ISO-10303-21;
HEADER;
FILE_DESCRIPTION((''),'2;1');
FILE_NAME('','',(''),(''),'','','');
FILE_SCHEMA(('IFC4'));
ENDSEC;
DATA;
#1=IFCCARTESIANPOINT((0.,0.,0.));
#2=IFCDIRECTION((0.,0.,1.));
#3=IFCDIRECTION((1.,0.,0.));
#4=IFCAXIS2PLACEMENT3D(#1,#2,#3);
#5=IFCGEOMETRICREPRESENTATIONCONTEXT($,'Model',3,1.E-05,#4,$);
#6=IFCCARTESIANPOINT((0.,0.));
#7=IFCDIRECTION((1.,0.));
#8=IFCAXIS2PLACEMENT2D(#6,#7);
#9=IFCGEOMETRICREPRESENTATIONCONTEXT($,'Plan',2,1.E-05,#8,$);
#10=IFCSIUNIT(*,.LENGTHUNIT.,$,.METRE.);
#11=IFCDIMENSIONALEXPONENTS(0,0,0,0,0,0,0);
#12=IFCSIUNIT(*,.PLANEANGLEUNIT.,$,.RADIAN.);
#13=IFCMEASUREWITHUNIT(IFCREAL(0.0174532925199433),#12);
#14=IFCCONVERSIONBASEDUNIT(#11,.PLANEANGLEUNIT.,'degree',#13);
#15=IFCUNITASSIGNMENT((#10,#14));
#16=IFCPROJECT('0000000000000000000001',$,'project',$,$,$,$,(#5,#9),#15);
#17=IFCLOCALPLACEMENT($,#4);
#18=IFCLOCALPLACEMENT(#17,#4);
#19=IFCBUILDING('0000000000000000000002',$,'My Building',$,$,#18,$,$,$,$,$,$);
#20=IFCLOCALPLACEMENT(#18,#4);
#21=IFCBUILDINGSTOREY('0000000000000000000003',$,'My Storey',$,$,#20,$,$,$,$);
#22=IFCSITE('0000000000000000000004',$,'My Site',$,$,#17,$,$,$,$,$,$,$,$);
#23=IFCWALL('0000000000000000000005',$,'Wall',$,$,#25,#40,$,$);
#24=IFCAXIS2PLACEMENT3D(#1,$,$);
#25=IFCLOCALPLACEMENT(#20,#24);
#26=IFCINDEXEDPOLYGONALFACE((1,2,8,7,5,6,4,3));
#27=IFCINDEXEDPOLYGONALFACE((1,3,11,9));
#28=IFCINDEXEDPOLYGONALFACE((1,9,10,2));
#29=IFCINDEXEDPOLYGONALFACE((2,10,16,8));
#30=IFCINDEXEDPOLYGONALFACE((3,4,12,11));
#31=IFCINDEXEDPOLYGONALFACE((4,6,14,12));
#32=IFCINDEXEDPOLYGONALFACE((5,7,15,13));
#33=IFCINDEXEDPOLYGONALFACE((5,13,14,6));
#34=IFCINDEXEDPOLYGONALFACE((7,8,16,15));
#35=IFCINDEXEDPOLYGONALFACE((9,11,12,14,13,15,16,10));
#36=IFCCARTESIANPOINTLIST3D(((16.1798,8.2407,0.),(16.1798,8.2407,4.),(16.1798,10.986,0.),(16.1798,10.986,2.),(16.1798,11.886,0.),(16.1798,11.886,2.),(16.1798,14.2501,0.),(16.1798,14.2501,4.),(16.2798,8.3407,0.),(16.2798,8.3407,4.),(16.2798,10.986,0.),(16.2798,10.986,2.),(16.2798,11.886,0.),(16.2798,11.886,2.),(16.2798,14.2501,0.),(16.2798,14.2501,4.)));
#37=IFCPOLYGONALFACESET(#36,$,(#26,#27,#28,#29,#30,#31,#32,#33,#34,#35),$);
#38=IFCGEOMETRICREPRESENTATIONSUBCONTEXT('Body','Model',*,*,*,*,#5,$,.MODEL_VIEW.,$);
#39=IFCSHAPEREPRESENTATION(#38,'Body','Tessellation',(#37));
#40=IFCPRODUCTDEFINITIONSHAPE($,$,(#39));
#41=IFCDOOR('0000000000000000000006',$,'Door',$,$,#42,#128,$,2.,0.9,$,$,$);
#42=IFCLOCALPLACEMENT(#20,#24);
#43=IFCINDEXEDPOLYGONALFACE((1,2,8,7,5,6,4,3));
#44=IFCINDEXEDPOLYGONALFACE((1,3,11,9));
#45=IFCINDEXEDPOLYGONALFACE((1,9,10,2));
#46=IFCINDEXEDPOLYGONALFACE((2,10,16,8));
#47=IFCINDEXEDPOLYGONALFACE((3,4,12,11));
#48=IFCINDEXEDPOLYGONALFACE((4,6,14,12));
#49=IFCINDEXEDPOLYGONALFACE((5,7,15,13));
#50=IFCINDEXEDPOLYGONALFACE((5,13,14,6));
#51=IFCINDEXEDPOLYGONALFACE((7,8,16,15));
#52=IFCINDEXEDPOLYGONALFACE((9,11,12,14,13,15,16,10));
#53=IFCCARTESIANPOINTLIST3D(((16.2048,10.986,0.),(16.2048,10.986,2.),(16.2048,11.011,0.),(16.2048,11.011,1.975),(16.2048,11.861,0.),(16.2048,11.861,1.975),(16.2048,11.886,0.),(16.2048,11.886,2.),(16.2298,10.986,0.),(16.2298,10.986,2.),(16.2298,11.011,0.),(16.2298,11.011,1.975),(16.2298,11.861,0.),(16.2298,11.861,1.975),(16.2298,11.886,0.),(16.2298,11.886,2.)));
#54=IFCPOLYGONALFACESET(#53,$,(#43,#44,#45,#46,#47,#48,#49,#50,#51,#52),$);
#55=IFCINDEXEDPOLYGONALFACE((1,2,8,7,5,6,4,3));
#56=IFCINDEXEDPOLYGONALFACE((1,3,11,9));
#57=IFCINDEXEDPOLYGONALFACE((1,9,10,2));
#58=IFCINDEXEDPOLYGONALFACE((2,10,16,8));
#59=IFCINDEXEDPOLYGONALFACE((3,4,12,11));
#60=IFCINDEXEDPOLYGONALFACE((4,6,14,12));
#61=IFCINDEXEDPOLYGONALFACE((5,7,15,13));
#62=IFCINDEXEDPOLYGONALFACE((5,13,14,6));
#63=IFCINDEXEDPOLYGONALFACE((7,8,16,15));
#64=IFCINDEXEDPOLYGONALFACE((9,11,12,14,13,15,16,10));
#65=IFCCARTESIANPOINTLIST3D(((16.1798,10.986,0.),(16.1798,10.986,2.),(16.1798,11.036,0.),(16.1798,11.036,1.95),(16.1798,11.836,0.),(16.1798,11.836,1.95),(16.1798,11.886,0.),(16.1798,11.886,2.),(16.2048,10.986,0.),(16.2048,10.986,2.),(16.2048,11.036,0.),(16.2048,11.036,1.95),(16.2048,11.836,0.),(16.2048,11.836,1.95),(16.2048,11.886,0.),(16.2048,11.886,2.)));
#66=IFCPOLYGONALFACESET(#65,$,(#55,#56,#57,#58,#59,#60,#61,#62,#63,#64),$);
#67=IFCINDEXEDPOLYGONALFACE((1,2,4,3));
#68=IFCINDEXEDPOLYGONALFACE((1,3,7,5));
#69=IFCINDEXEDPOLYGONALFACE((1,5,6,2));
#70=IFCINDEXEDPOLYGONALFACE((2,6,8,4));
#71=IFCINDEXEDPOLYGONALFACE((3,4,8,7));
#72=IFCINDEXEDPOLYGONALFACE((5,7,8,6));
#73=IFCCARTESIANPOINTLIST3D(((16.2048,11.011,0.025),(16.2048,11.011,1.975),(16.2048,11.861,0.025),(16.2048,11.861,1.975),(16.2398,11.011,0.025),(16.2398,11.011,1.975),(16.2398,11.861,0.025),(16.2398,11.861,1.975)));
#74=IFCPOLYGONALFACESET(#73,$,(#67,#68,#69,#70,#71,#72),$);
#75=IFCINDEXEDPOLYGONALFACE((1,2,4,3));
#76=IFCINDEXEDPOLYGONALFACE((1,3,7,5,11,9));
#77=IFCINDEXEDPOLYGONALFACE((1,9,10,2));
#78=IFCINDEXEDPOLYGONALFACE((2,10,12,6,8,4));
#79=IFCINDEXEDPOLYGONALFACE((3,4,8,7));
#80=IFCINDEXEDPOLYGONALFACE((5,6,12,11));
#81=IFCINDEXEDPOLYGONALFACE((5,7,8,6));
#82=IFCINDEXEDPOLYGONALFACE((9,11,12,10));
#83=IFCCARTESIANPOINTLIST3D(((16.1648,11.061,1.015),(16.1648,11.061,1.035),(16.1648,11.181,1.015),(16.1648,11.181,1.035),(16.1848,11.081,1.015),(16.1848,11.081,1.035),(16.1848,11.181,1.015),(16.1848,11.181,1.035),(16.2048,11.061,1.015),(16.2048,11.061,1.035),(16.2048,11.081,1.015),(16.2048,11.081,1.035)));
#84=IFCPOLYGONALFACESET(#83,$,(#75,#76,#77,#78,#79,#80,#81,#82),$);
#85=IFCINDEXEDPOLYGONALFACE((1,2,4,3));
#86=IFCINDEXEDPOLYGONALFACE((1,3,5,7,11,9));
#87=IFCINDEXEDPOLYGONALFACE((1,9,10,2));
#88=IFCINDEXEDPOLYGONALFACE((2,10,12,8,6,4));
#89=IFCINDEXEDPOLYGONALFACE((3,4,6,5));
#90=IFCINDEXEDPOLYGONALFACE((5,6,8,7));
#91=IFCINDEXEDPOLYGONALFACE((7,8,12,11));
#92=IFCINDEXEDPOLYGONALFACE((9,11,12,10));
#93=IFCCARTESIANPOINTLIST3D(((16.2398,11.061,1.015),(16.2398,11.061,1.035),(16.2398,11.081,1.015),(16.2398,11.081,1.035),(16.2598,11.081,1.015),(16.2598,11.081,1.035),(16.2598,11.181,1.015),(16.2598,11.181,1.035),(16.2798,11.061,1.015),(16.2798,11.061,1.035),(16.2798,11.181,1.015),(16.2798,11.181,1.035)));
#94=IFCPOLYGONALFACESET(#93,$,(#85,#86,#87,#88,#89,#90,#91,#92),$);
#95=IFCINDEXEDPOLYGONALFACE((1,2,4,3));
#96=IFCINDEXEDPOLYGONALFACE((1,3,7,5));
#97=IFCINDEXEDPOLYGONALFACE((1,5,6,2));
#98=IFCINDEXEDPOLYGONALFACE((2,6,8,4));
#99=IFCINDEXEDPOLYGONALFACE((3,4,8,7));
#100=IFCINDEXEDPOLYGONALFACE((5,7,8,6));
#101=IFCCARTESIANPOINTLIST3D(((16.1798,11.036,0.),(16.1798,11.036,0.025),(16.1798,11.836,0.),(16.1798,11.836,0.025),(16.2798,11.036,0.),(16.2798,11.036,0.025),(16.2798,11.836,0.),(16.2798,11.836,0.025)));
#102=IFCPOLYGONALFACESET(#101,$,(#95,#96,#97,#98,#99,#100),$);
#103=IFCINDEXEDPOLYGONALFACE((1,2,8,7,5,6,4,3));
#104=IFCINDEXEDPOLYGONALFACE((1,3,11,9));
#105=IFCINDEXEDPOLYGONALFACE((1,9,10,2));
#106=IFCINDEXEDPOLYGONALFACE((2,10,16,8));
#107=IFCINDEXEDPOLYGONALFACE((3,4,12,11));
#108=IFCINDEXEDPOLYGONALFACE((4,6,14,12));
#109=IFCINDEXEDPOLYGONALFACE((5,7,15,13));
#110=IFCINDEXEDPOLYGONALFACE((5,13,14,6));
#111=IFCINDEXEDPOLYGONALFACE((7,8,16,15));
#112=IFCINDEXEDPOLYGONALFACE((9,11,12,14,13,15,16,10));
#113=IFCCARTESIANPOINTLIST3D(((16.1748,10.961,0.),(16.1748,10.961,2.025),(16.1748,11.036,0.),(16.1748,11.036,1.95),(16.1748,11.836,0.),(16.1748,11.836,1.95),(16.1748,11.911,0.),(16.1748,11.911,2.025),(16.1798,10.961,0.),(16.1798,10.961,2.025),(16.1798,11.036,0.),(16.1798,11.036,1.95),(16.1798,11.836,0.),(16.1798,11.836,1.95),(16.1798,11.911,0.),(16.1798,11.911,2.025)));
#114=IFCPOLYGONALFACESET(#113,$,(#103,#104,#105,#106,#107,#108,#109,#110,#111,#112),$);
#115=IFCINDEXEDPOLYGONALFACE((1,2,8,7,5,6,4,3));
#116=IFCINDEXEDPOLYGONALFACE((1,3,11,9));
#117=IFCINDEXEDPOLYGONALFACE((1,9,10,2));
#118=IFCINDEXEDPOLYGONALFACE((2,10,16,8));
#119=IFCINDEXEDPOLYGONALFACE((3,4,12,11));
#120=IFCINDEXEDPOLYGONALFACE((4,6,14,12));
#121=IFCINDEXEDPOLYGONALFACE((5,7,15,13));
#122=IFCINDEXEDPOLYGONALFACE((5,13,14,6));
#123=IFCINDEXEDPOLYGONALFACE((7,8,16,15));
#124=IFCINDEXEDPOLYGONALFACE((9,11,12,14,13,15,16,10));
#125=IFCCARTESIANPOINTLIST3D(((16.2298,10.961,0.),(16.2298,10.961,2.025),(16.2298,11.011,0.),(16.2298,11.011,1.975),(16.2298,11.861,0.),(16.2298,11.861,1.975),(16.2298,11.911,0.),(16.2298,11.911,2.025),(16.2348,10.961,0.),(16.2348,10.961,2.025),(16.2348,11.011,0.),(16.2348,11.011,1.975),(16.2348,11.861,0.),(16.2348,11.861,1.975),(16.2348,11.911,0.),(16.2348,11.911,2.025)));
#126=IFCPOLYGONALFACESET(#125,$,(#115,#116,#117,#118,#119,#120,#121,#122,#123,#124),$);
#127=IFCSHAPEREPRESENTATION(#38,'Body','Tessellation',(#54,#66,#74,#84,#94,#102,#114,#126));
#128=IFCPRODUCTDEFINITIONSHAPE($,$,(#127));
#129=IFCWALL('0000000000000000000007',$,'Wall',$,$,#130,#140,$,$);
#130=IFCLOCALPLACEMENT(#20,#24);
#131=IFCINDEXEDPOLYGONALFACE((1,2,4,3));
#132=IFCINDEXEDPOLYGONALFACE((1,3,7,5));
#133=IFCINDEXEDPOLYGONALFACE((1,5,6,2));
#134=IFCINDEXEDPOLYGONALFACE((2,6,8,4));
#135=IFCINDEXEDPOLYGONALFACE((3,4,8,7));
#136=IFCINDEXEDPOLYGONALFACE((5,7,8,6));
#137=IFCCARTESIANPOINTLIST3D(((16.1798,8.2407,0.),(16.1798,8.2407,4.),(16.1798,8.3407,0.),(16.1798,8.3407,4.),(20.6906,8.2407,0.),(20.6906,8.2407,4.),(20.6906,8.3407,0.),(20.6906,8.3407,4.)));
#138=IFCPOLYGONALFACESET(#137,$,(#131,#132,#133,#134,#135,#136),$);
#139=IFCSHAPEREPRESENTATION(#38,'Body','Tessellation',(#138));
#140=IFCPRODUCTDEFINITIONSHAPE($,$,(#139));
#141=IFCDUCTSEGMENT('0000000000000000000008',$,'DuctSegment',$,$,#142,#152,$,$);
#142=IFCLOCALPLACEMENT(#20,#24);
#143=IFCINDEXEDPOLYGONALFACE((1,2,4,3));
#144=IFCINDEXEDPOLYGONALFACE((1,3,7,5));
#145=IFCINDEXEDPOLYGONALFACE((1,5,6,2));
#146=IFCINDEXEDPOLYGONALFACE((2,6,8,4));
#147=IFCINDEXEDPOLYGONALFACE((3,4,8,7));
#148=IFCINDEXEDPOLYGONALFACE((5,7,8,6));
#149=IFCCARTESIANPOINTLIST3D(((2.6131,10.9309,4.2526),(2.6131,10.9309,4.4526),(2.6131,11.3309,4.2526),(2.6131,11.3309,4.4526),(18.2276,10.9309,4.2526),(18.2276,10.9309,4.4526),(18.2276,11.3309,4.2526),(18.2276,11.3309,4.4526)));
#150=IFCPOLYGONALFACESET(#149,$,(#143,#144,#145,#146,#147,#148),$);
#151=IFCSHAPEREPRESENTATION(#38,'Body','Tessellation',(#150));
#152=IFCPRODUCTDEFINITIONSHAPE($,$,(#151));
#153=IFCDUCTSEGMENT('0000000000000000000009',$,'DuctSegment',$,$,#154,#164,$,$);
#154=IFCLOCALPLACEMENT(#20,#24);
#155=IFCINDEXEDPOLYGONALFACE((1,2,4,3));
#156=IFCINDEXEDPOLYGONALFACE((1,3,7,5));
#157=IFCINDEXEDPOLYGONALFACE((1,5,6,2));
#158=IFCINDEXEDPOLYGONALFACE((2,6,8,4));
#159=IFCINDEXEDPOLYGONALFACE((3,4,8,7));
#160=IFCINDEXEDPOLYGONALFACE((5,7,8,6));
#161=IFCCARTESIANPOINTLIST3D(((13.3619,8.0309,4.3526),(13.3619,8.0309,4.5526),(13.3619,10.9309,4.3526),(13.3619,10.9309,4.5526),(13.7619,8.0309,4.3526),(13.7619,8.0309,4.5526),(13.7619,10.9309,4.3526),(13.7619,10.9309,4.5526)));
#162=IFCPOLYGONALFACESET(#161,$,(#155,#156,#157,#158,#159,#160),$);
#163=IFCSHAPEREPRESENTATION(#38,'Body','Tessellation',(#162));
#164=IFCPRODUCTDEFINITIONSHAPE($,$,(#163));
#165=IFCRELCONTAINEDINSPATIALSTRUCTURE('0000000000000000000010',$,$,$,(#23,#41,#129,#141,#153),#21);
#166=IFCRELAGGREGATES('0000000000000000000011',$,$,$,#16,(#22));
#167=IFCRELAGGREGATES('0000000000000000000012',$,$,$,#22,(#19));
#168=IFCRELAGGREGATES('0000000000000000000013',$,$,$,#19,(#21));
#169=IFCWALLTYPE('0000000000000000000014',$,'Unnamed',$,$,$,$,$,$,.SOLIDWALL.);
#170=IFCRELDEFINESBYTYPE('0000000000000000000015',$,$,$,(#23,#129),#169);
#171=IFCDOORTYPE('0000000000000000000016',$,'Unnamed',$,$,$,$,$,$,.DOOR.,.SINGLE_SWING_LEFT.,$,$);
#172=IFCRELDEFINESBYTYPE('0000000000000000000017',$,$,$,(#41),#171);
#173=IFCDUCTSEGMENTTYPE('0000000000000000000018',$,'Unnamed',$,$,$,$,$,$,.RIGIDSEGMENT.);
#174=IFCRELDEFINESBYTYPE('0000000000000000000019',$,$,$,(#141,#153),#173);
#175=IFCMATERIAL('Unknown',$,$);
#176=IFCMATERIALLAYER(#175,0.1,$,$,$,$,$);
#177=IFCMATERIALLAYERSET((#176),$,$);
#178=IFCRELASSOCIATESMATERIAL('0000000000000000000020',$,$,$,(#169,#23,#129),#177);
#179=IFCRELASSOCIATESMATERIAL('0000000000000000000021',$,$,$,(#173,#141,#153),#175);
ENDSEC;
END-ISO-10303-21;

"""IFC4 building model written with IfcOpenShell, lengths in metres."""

from ifc_helpers import new_model, entity, si_unit, converted_unit, frame, origin_with_axes, origin_2d_with_axis, place, context, subcontext, project, spatial, line, indexed_curve, rectangle, outline, extrude, shape, source, transform, mapped, material, layer, layer_set, layer_usage, material_profile, profile_set, profile_usage, type_object, type_shapes, element, fill, save


model = new_model("IFC4")

# Units and contexts
model_context = context("Model", 3, precision=1e-05, world=origin_with_axes())
plan_context = context("Plan", 2, precision=1e-05, world=origin_2d_with_axis())
body_context_1 = subcontext(model_context, "Body", "Model", "MODEL_VIEW")
body_context_2 = subcontext(plan_context, "Body", "Plan", "PLAN_VIEW")
ifc_project = project(units=[si_unit("LENGTHUNIT", "METRE"), converted_unit("PLANEANGLEUNIT", "degree", entity("IfcReal", 0.0174532925199433), si_unit("PLANEANGLEUNIT", "RADIAN"), dimensions=[0, 0, 0, 0, 0, 0, 0])], contexts=[model_context, plan_context])

# Site, building, storey
site_placement = place(None, origin_with_axes())
site = spatial("IfcSite", under=ifc_project, at=site_placement, Name="My Site")
building_placement = place(site_placement, origin_with_axes())
building = spatial("IfcBuilding", under=site, at=building_placement, Name="My Building")
storey_placement = place(building_placement, origin_with_axes())
storey = spatial("IfcBuildingStorey", under=building, at=storey_placement, Name="My Storey")

# Shared definitions
ifc_material = material(Name="Unknown")

# Wall, opening, door
ifc_layer_1 = layer(ifc_material, 0.1)
ifc_layer_set_1 = layer_set([ifc_layer_1])
wall_type = type_object("IfcWallType", Name="Unnamed", PredefinedType="SOLIDWALL", material=ifc_layer_set_1)
shared_shape_1 = source(origin_with_axes(), body_context_1, "Body", "SweptSolid", [
    extrude(outline(indexed_curve([(0.0, 0.0), (0.9, 0.0), (0.9, 2.0), (0.0, 2.0)], segments=[line(1, 2, 3, 4, 1)])), frame((0.0, -0.6, 0.0), z_axis=(0.0, -1.0, 0.0), x_axis=(1.0, 0.0, 0.0)), (0.0, 0.0, -1.0), 1.2),
])
door_type = type_object("IfcDoorType", Name="Unnamed", OperationType="SINGLE_SWING_LEFT", PredefinedType="DOOR")
shared_shape_2 = source(origin_with_axes(), body_context_1, "Body", "SweptSolid", [
    extrude(outline(indexed_curve([(0.0, 0.0), (0.0, 2.0), (0.9, 2.0), (0.9, 0.0), (0.875, 0.0), (0.875, 1.975), (0.025, 1.975), (0.025, 0.0)], segments=[line(1, 2, 3, 4, 5, 6, 7, 8, 1)])), frame((0.0, 0.025, 0.0), z_axis=(0.0, -1.0, 0.0), x_axis=(1.0, 0.0, 0.0)), (0.0, 0.0, -1.0), 0.025),
    extrude(outline(indexed_curve([(0.0, 0.0), (0.0, 2.0), (0.9, 2.0), (0.9, 0.0), (0.85, 0.0), (0.85, 1.95), (0.05, 1.95), (0.05, 0.0)], segments=[line(1, 2, 3, 4, 5, 6, 7, 8, 1)])), frame((0.0, 0.0, 0.0), z_axis=(0.0, -1.0, 0.0), x_axis=(1.0, 0.0, 0.0)), (0.0, 0.0, -1.0), 0.025),
    extrude(outline(indexed_curve([(0.0, 0.0), (0.85, 0.0), (0.85, 0.035), (0.0, 0.035)], segments=[line(1, 2, 3, 4, 1)])), frame((0.025, 0.025, 0.025), z_axis=(0.0, 0.0, 1.0), x_axis=(1.0, 0.0, 0.0)), (0.0, 0.0, 1.0), 1.95),
    extrude(outline(indexed_curve([(0.0, 0.0), (0.0, -0.04), (-0.12, -0.04), (-0.12, -0.02), (-0.02, -0.02), (-0.02, 0.0)], segments=[line(1, 2, 3, 4, 5, 6, 1)])), frame((0.825, 0.025, 1.015), z_axis=(0.0, 0.0, 1.0), x_axis=(1.0, 0.0, 0.0)), (0.0, 0.0, 1.0), 0.02),
    extrude(outline(indexed_curve([(0.0, 0.0), (0.0, 0.04), (-0.12, 0.04), (-0.12, 0.02), (-0.02, 0.02), (-0.02, 0.0)], segments=[line(1, 2, 3, 4, 5, 6, 1)])), frame((0.825, 0.06, 1.015), z_axis=(0.0, 0.0, 1.0), x_axis=(1.0, 0.0, 0.0)), (0.0, 0.0, 1.0), 0.02),
    extrude(outline(indexed_curve([(0.0, 0.0), (0.8, 0.0), (0.8, 0.1), (0.0, 0.1)], segments=[line(1, 2, 3, 4, 1)])), frame((0.05, 0.0, 0.0), z_axis=(0.0, 0.0, 1.0), x_axis=(1.0, 0.0, 0.0)), (0.0, 0.0, 1.0), 0.025),
    extrude(outline(indexed_curve([(0.0, 0.0), (0.0, 2.025), (0.95, 2.025), (0.95, 0.0), (0.875, 0.0), (0.875, 1.95), (0.075, 1.95), (0.075, 0.0)], segments=[line(1, 2, 3, 4, 5, 6, 7, 8, 1)])), frame((-0.025, -0.005, 0.0), z_axis=(0.0, -1.0, 0.0), x_axis=(1.0, 0.0, 0.0)), (0.0, 0.0, -1.0), 0.005),
    extrude(outline(indexed_curve([(0.0, 0.0), (0.0, 2.025), (0.95, 2.025), (0.95, 0.0), (0.9, 0.0), (0.9, 1.975), (0.05, 1.975), (0.05, 0.0)], segments=[line(1, 2, 3, 4, 5, 6, 7, 8, 1)])), frame((-0.025, 0.05, 0.0), z_axis=(0.0, -1.0, 0.0), x_axis=(1.0, 0.0, 0.0)), (0.0, 0.0, -1.0), 0.005),
])
shared_shape_3 = source(origin_with_axes(), body_context_2, "Body", "Curve2D", [
    entity("IfcIndexedPolyCurve", entity("IfcCartesianPointList2D", [[0.0, 0.0], [0.0, 0.05], [0.025, 0.05], [0.025, 0.025], [0.05, 0.025], [0.05, 0.0]]), [entity("IfcLineIndex", [1, 2, 3, 4, 5, 6, 1])]),
    entity("IfcIndexedPolyCurve", entity("IfcCartesianPointList2D", [[0.9, 0.0], [0.9, 0.05], [0.875, 0.05], [0.875, 0.025], [0.85, 0.025], [0.85, 0.0]]), [entity("IfcLineIndex", [1, 2, 3, 4, 5, 6, 1])]),
    entity("IfcTrimmedCurve", entity("IfcEllipse", entity("IfcAxis2Placement2D", entity("IfcCartesianPoint", [0.06, 0.05]), entity("IfcDirection", [1.0, 0.0])), 0.815, 0.85), [entity("IfcCartesianPoint", [0.875, 0.05])], [entity("IfcCartesianPoint", [0.06, 0.9])], True, "CARTESIAN"),
    entity("IfcIndexedPolyCurve", entity("IfcCartesianPointList2D", [[0.025, 0.05], [0.06, 0.05], [0.06, 0.9], [0.025, 0.9]]), [entity("IfcLineIndex", [1, 2, 3, 4, 1])]),
])
type_shapes(door_type, [shared_shape_2, shared_shape_3])
ifc_layer_usage_1 = layer_usage(ifc_layer_set_1, "AXIS2", "POSITIVE", 0.0)
wall_1_placement = place(storey_placement, frame((16.1798, 14.2501, 0.0), z_axis=(0.0, 0.0, 1.0), x_axis=(0.0, -1.0, 0.0)))
wall_1 = element("IfcWall", 1, at=wall_1_placement, inside=storey, type_object=wall_type, material=ifc_layer_usage_1, Name="Wall", context=body_context_1, shape_type="SweptSolid", body=[
    extrude(outline(indexed_curve([(0.0, 0.0), (0.0, 0.1), (5.9093, 0.1), (6.0093, 0.0)], segments=[line(1, 2, 3, 4, 1)])), origin_with_axes(), (0.0, 0.0, 1.0), 4.0),
])
opening_1_placement = place(wall_1_placement, frame((2.364, 0.0, 0.0), z_axis=(0.0, 0.0, 1.0), x_axis=(1.0, 0.0, 0.0)))
opening_1 = element("IfcOpeningElement", 2, at=opening_1_placement, cuts=wall_1, PredefinedType="OPENING", context=body_context_1, shape_type="MappedRepresentation", body=[
    mapped(shared_shape_1, transform((0.0, 0.0, 0.0), x_axis=(1.0, 0.0, 0.0), y_axis=(0.0, 1.0, 0.0), z_axis=(0.0, 0.0, 1.0), scale=1.0)),
])
door_1_placement = place(opening_1_placement, frame((0.0, 0.0, 0.0), z_axis=(0.0, 0.0, 1.0), x_axis=(1.0, 0.0, 0.0)))
door_1 = element("IfcDoor", 3, at=door_1_placement, inside=storey, type_object=door_type, Name="Door", OverallHeight=2.0, OverallWidth=0.9, shapes=[
    shape(body_context_1, "Body", "MappedRepresentation", [mapped(shared_shape_2, transform((0.0, 0.0, 0.0), x_axis=(1.0, 0.0, 0.0), y_axis=(0.0, 1.0, 0.0), z_axis=(0.0, 0.0, 1.0), scale=1.0))]),
    shape(body_context_2, "Body", "MappedRepresentation", [mapped(shared_shape_3, transform((0.0, 0.0, 0.0), x_axis=(1.0, 0.0, 0.0), y_axis=(0.0, 1.0, 0.0), z_axis=(0.0, 0.0, 1.0), scale=1.0))]),
])
fill(opening_1, door_1)

# Wall
ifc_layer_usage_2 = layer_usage(ifc_layer_set_1, "AXIS2", "POSITIVE", 0.0)
wall_2_placement = place(storey_placement, frame((16.1798, 8.2407, 0.0), z_axis=(0.0, 0.0, 1.0), x_axis=(1.0, 0.0, 0.0)))
element("IfcWall", 4, at=wall_2_placement, inside=storey, type_object=wall_type, material=ifc_layer_usage_2, Name="Wall", context=body_context_1, shape_type="SweptSolid", body=[
    extrude(outline(indexed_curve([(0.0, 0.0), (0.0, 0.1), (4.5108, 0.1), (4.5108, 0.0)], segments=[line(1, 2, 3, 4, 1)])), origin_with_axes(), (0.0, 0.0, 1.0), 4.0),
])

# Duct segments
ifc_material_profile_1 = material_profile(ifc_material, rectangle(XDim=0.4, YDim=0.2))
ifc_profile_set_1 = profile_set([ifc_material_profile_1])
ifc_profile_usage_1 = profile_usage(ifc_profile_set_1, cardinal=5)
duct_segment_type = type_object("IfcDuctSegmentType", Name="Unnamed", PredefinedType="RIGIDSEGMENT", material=ifc_profile_set_1)
duct_segment_1_placement = place(storey_placement, frame((18.2276, 11.1309, 4.3526), z_axis=(-1.0, 0.0, 0.0), x_axis=(0.0, -1.0, 0.0)))
element("IfcDuctSegment", 5, at=duct_segment_1_placement, inside=storey, type_object=duct_segment_type, material=ifc_profile_usage_1, Name="DuctSegment", context=body_context_1, shape_type="SweptSolid", body=[
    extrude(rectangle(XDim=0.4, YDim=0.2), origin_with_axes(), (0.0, 0.0, 1.0), 15.6145),
])
ifc_profile_usage_2 = profile_usage(ifc_profile_set_1, cardinal=5)
duct_segment_2_placement = place(storey_placement, frame((13.5619, 10.9309, 4.4526), z_axis=(0.0, -1.0, 0.0), x_axis=(1.0, 0.0, 0.0)))
element("IfcDuctSegment", 6, at=duct_segment_2_placement, inside=storey, type_object=duct_segment_type, material=ifc_profile_usage_2, Name="DuctSegment", context=body_context_1, shape_type="SweptSolid", body=[
    extrude(rectangle(XDim=0.4, YDim=0.2), origin_with_axes(), (0.0, 0.0, 1.0), 2.9),
])

save(model, "model.ifc")
